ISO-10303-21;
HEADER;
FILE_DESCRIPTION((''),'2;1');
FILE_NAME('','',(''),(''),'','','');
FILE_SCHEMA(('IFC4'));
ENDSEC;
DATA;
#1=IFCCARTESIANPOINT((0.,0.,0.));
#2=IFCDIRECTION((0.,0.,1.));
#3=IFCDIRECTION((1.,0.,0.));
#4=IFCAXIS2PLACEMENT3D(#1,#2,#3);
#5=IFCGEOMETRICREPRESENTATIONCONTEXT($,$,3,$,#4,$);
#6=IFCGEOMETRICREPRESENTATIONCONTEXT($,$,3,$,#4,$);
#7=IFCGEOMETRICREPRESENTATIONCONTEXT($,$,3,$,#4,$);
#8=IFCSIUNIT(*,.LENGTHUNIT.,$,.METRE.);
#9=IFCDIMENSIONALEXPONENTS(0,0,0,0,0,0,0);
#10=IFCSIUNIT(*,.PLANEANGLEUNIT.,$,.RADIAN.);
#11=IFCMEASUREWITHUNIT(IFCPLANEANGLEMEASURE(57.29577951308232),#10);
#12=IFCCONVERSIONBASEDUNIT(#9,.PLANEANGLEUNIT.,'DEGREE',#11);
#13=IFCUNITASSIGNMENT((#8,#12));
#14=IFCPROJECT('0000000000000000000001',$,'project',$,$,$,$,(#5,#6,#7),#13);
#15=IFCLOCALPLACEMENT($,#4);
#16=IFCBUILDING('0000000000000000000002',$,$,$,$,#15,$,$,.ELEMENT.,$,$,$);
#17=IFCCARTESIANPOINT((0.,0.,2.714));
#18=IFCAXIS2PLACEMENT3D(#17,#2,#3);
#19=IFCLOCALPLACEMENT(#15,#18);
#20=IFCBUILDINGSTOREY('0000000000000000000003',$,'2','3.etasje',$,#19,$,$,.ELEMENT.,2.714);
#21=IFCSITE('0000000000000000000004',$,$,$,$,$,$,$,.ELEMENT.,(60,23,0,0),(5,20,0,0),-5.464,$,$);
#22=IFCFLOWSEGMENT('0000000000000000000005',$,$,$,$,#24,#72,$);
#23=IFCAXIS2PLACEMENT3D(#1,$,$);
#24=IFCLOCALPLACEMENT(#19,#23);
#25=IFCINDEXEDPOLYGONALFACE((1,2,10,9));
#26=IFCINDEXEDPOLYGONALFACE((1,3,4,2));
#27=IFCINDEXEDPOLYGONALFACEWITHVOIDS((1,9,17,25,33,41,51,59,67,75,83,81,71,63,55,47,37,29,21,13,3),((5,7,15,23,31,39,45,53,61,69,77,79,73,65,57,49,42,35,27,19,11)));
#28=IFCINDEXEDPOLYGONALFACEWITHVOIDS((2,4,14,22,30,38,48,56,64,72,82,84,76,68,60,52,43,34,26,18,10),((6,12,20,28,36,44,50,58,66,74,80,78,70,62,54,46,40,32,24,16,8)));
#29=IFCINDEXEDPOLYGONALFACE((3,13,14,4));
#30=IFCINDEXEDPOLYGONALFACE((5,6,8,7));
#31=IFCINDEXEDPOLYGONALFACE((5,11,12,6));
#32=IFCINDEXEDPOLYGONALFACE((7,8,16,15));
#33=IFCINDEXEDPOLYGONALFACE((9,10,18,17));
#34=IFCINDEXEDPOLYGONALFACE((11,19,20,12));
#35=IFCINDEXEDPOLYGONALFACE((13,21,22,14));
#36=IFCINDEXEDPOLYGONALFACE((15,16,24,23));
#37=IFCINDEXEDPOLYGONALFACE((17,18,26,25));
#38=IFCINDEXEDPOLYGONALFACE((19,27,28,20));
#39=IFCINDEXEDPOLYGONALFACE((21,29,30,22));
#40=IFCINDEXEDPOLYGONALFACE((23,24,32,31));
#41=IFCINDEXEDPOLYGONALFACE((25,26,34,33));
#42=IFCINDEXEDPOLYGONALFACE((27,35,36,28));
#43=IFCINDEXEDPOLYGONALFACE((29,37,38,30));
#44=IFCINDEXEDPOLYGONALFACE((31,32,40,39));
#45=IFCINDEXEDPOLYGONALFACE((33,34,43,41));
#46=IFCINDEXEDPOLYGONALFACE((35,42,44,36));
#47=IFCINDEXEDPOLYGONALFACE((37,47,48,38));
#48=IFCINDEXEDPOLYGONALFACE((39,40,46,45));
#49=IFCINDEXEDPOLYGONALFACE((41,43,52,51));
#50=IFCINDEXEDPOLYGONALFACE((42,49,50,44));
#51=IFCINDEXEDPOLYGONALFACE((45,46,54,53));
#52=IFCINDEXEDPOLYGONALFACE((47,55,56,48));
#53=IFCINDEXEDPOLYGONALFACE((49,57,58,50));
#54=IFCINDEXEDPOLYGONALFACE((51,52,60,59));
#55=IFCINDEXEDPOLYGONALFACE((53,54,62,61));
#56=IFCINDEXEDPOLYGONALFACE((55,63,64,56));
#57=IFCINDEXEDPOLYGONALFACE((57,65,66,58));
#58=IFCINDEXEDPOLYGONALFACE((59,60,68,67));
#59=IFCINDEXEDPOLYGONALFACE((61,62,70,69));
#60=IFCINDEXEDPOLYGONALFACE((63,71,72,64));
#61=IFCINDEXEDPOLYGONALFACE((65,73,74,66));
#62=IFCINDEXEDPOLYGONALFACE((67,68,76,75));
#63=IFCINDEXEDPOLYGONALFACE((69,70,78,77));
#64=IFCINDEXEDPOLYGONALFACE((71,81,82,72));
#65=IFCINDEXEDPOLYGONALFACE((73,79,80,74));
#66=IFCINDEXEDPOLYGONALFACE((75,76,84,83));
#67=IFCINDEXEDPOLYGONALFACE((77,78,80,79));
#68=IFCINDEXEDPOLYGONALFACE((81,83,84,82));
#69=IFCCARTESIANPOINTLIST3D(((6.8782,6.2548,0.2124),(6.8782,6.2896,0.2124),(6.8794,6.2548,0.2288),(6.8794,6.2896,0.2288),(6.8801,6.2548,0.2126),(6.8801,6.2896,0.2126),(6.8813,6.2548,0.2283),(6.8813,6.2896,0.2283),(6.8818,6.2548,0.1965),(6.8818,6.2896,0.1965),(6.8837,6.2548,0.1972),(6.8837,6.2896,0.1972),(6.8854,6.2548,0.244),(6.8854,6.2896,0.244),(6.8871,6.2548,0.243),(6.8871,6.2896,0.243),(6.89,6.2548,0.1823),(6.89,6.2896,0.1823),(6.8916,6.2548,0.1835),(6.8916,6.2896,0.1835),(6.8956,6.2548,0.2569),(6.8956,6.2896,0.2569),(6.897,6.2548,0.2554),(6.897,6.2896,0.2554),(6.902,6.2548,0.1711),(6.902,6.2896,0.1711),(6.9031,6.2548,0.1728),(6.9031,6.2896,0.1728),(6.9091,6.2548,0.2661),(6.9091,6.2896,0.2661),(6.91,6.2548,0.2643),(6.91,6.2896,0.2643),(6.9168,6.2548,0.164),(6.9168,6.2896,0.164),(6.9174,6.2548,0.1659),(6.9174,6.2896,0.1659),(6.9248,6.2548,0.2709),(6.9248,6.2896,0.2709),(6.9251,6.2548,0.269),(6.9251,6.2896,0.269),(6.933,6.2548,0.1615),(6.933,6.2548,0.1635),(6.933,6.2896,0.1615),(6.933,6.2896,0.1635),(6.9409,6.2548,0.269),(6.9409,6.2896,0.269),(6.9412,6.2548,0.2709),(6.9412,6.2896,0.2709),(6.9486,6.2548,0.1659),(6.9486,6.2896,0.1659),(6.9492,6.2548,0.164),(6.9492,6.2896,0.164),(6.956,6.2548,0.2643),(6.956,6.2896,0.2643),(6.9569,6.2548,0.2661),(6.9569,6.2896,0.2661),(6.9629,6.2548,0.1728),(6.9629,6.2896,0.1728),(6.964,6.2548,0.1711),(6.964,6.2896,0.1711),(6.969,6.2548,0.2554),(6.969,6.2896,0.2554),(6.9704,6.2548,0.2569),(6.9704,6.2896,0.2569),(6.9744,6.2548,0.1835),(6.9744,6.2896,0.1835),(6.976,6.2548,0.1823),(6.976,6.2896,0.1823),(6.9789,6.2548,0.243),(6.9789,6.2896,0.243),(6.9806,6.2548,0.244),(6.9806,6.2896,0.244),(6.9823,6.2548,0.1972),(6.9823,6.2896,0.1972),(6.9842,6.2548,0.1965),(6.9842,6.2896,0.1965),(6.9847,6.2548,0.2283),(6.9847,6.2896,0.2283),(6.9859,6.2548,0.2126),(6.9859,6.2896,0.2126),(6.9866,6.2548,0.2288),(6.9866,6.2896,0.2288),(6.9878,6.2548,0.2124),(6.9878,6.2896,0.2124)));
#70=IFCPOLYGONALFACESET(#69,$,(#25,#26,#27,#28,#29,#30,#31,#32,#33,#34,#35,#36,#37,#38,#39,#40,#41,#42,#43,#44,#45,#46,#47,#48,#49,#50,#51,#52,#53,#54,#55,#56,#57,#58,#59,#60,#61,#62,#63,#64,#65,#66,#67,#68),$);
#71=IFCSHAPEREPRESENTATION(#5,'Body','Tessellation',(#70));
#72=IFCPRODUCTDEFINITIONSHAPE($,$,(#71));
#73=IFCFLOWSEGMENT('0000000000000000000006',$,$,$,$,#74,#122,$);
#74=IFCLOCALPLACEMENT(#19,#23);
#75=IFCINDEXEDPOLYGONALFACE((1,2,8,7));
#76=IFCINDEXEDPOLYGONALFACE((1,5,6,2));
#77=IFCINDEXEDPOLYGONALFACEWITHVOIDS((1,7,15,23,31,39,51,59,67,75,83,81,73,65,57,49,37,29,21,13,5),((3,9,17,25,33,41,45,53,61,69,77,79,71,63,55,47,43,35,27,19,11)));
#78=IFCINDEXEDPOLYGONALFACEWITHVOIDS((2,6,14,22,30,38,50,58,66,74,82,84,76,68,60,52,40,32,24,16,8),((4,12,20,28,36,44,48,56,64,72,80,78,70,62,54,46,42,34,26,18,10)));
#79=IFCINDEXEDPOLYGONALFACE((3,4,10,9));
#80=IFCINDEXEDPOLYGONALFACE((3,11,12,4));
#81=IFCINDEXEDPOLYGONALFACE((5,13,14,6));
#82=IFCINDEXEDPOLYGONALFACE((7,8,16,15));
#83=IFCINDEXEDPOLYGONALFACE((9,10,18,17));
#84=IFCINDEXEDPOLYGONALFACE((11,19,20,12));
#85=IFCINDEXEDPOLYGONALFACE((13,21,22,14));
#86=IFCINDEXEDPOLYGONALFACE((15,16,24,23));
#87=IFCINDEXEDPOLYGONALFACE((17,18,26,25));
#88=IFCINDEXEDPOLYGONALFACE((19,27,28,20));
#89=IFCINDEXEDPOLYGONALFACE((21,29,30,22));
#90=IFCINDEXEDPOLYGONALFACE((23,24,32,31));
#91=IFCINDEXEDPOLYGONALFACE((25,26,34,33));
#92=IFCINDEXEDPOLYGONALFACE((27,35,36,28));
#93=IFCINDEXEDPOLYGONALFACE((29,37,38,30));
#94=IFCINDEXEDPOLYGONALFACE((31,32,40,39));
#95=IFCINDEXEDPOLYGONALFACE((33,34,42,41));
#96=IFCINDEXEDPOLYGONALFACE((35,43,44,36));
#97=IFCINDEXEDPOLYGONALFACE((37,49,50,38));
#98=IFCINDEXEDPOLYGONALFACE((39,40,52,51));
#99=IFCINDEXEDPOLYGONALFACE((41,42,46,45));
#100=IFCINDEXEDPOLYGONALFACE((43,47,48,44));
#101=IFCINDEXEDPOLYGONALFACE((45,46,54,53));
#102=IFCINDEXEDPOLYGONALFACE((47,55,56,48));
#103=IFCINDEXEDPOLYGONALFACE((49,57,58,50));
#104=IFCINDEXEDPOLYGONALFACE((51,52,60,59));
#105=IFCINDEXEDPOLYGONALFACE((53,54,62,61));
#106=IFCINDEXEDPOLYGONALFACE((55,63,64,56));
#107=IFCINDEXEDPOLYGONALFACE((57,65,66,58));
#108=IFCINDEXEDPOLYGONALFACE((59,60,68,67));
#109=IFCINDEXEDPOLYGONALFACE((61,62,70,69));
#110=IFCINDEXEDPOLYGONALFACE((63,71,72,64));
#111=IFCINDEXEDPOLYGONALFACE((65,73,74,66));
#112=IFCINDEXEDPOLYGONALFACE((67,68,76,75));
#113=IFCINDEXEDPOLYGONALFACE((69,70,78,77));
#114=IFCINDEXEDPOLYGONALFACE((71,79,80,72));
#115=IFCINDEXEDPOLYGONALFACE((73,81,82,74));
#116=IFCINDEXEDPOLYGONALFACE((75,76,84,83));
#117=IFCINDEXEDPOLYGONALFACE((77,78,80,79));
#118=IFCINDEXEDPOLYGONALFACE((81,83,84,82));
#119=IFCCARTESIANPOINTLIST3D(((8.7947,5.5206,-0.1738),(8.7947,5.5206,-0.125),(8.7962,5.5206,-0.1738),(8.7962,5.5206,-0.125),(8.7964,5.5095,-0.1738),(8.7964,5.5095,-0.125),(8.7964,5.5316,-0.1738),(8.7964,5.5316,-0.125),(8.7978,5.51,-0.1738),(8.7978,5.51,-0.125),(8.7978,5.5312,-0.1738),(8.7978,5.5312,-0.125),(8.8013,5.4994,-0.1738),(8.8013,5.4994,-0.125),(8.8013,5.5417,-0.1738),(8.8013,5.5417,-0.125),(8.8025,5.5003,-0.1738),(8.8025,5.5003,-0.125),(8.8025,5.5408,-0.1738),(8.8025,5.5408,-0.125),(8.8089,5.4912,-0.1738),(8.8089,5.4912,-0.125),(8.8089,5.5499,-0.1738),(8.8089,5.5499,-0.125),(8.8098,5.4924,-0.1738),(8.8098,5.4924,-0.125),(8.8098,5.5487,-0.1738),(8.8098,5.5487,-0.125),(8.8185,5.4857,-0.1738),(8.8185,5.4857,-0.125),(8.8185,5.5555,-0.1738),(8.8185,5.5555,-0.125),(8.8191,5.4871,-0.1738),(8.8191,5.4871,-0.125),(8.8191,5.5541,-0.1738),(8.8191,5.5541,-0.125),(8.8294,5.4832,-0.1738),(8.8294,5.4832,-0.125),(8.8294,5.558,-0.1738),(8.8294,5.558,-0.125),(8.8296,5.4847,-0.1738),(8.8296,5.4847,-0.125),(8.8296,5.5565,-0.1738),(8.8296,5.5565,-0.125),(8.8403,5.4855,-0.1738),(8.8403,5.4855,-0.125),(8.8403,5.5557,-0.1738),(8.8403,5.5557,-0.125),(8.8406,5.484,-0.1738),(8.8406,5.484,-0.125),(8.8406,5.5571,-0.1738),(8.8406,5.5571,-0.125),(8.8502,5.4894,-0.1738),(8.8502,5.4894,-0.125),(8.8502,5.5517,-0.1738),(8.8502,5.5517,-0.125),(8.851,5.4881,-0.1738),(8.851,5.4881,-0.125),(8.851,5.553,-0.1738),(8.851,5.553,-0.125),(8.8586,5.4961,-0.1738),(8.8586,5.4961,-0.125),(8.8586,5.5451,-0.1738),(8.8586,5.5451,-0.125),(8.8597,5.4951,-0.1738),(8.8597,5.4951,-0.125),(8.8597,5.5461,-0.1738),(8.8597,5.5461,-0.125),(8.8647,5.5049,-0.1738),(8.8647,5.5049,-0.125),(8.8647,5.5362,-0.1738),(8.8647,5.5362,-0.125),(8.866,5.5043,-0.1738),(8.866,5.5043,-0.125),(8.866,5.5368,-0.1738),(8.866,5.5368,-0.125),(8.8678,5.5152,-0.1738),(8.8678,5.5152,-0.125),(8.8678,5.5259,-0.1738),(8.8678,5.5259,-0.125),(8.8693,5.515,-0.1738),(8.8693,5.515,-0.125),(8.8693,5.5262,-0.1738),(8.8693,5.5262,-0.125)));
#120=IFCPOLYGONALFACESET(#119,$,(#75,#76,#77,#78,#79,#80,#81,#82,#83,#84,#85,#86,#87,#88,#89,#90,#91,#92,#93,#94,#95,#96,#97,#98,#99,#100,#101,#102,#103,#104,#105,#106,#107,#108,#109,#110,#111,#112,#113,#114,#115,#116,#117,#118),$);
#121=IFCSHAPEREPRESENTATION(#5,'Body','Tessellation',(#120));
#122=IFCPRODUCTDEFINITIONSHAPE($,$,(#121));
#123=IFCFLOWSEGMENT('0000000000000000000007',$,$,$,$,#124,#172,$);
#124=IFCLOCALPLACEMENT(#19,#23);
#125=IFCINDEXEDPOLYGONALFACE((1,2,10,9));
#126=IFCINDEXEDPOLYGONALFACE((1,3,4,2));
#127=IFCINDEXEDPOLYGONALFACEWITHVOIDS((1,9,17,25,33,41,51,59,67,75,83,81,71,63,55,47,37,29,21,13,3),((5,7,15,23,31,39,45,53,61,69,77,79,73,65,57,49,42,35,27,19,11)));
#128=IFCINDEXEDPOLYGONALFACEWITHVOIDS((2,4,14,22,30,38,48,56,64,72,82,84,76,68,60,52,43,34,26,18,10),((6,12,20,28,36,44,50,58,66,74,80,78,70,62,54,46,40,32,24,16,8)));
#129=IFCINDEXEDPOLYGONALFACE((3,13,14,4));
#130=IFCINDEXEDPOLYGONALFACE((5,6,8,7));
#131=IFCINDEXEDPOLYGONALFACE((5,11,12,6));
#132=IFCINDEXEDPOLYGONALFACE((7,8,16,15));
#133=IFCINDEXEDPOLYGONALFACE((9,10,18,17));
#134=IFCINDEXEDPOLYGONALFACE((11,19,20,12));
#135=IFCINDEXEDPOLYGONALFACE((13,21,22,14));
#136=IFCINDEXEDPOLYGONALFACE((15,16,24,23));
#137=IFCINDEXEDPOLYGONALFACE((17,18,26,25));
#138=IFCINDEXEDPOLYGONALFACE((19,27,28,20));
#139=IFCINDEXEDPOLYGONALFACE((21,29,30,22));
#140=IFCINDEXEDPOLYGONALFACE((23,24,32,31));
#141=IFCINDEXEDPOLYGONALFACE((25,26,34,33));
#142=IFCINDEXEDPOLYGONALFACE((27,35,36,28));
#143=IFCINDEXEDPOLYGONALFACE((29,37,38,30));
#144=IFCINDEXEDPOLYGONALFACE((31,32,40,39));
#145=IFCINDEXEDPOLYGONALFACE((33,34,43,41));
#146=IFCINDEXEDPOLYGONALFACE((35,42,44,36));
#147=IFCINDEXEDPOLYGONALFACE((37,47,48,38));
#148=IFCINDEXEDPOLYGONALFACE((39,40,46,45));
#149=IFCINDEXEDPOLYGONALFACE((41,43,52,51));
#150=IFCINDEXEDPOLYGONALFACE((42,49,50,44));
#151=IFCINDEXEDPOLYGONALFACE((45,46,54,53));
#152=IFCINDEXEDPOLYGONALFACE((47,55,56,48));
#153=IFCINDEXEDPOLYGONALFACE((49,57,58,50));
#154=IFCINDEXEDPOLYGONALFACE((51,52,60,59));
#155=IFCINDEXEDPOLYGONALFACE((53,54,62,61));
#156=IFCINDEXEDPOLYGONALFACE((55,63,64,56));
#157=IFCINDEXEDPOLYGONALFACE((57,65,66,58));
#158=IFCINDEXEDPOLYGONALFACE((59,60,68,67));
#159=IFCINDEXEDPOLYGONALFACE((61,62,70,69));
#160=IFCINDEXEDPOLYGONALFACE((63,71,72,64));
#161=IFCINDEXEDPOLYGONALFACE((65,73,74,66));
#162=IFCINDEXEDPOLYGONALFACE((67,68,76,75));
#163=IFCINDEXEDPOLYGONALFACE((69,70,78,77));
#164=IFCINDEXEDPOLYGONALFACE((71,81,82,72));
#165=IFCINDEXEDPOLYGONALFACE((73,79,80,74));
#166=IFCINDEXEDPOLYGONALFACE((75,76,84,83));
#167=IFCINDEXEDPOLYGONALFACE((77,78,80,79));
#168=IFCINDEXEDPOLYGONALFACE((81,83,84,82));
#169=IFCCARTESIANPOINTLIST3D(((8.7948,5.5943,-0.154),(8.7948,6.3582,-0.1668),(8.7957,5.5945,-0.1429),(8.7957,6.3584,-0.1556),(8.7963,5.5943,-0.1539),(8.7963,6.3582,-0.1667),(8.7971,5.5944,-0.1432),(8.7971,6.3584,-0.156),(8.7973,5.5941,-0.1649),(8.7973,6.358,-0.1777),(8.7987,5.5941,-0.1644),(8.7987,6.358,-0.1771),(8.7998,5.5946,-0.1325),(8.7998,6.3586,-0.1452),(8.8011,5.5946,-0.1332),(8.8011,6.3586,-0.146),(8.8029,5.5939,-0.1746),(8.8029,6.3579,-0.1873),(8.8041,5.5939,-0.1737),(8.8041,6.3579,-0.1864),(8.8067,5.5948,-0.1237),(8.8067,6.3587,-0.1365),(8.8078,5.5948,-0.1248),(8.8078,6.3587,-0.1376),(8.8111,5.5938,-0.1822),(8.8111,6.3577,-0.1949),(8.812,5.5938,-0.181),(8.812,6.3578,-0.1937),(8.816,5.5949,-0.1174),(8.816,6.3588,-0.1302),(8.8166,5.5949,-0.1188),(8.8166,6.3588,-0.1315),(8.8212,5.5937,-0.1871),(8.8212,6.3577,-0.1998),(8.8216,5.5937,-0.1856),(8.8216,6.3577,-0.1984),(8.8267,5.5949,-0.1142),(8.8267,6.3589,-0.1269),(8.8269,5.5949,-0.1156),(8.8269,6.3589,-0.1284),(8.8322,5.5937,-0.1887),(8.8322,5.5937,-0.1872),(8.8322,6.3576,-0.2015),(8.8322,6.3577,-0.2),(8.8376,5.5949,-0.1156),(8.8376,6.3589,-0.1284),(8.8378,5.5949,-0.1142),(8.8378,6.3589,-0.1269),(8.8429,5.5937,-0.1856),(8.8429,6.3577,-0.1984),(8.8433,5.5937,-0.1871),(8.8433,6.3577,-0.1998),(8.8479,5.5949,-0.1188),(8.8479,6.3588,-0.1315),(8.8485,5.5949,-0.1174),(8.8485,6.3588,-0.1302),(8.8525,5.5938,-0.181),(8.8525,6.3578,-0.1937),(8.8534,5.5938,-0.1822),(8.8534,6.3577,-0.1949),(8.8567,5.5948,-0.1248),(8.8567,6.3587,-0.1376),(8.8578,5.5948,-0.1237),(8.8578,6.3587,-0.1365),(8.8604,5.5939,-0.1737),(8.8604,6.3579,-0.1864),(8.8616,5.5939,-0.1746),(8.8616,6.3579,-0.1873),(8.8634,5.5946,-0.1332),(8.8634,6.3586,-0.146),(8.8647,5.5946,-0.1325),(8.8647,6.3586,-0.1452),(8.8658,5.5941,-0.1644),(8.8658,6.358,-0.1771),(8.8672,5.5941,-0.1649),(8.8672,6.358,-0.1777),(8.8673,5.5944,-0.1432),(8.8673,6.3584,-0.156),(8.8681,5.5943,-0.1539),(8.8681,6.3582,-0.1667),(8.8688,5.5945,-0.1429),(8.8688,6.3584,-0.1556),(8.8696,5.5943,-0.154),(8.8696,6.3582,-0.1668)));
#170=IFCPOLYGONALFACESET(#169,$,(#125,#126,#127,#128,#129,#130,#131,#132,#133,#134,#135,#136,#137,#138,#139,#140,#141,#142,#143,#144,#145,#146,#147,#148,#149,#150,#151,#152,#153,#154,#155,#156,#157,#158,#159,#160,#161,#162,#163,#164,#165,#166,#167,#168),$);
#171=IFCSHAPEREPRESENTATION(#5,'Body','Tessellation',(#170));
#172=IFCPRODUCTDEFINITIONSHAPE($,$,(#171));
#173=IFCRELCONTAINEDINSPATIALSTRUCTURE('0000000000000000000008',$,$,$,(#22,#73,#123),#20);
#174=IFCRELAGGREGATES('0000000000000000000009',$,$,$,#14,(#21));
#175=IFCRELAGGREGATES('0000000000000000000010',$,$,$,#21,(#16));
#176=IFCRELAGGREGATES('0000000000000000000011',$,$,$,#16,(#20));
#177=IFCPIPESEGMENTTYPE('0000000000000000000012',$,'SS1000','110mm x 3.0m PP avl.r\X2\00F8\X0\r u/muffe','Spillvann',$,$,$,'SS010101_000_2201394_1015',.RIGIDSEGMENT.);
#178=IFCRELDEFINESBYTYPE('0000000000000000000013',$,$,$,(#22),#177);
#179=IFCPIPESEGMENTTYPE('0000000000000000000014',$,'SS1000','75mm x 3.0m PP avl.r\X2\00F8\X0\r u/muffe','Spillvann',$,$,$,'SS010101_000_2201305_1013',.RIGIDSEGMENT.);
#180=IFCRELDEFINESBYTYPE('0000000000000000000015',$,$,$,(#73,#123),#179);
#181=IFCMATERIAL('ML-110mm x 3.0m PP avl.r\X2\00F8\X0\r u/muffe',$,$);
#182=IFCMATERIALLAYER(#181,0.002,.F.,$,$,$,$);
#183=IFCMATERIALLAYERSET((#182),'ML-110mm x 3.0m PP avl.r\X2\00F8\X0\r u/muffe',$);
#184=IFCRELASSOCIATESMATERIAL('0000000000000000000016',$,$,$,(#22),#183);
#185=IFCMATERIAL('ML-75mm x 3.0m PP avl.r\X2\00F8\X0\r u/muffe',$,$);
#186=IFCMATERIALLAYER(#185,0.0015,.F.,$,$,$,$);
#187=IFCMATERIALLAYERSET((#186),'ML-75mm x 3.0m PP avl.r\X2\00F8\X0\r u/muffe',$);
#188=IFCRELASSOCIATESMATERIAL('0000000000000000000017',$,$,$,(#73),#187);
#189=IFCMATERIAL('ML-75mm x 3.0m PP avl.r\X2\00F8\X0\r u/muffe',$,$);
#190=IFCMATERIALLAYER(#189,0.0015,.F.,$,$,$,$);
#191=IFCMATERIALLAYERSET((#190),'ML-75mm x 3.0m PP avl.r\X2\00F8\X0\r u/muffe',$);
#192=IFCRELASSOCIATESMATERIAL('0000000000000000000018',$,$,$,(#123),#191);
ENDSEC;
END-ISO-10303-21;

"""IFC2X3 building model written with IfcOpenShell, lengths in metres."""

from ifc_helpers import new_model, entity, si_unit, converted_unit, frame, origin_with_axes, origin_2d_with_axis, place, context, project, spatial, hollow_circle, extrude, material, layer, layer_set, layer_usage, type_object, element, save


model = new_model("IFC2X3")

# Units and contexts
context_of_model_1 = context(None, 3, world=origin_with_axes())
context_of_model_2 = context(None, 3, world=origin_with_axes())
context_of_model_3 = context(None, 3, world=origin_with_axes())
ifc_project = project(units=[si_unit("LENGTHUNIT", "METRE"), converted_unit("PLANEANGLEUNIT", "DEGREE", entity("IfcPlaneAngleMeasure", 57.29577951308232), si_unit("PLANEANGLEUNIT", "RADIAN"), dimensions=[0, 0, 0, 0, 0, 0, 0])], contexts=[context_of_model_1, context_of_model_2, context_of_model_3])

# Site, building, storey
site = spatial("IfcSite", under=ifc_project, CompositionType="ELEMENT", RefLatitude=(60, 23, 0, 0), RefLongitude=(5, 20, 0, 0), RefElevation=-5.464)
building_placement = place(None, origin_with_axes())
building = spatial("IfcBuilding", under=site, at=building_placement, CompositionType="ELEMENT")
storey_placement = place(building_placement, frame((0.0, 0.0, 2.714), z_axis=(0.0, 0.0, 1.0), x_axis=(1.0, 0.0, 0.0)))
storey = spatial("IfcBuildingStorey", under=building, at=storey_placement, Name="2", Description="3.etasje", CompositionType="ELEMENT", Elevation=2.714)

# Flow segments
pipe_segment_type_1 = type_object("IfcPipeSegmentType", Name="SS1000", Description="110mm x 3.0m PP avl.rør u/muffe", ApplicableOccurrence="Spillvann", ElementType="SS010101_000_2201394_1015", PredefinedType="RIGIDSEGMENT")
ifc_material_1 = material(Name="ML-110mm x 3.0m PP avl.rør u/muffe")
ifc_layer_1 = layer(ifc_material_1, 0.002, ventilated=False)
ifc_layer_set_1 = layer_set([ifc_layer_1], Name="ML-110mm x 3.0m PP avl.rør u/muffe")
ifc_layer_usage_1 = layer_usage(ifc_layer_set_1, "AXIS2", "POSITIVE", 0.0)
flow_segment_1_placement = place(storey_placement, frame((6.933, 6.2896, 0.2165), z_axis=(0.0, -1.0, 0.0), x_axis=(0.0, 0.0, -1.0)))
element("IfcFlowSegment", 1, at=flow_segment_1_placement, inside=storey, type_object=pipe_segment_type_1, material=ifc_layer_usage_1, context=context_of_model_1, shape_type="SweptSolid", body=[
    extrude(hollow_circle(Radius=0.055, WallThickness=0.002, at=origin_2d_with_axis()), origin_with_axes(), (0.0, 0.0, 1.0), 0.0348),
])
ifc_material_2 = material(Name="ML-75mm x 3.0m PP avl.rør u/muffe")
ifc_layer_2 = layer(ifc_material_2, 0.0015, ventilated=False)
ifc_layer_set_2 = layer_set([ifc_layer_2], Name="ML-75mm x 3.0m PP avl.rør u/muffe")
ifc_layer_usage_2 = layer_usage(ifc_layer_set_2, "AXIS2", "POSITIVE", 0.0)
pipe_segment_type_2 = type_object("IfcPipeSegmentType", Name="SS1000", Description="75mm x 3.0m PP avl.rør u/muffe", ApplicableOccurrence="Spillvann", ElementType="SS010101_000_2201305_1013", PredefinedType="RIGIDSEGMENT")
flow_segment_2_placement = place(storey_placement, frame((8.8322, 5.5206, -0.125), z_axis=(0.0, 0.0, -1.0), x_axis=(-1.0, 0.0, 0.0)))
element("IfcFlowSegment", 2, at=flow_segment_2_placement, inside=storey, type_object=pipe_segment_type_2, material=ifc_layer_usage_2, context=context_of_model_1, shape_type="SweptSolid", body=[
    extrude(hollow_circle(Radius=0.0375, WallThickness=0.0015, at=origin_2d_with_axis()), origin_with_axes(), (0.0, 0.0, 1.0), 0.0488),
])
ifc_material_3 = material(Name="ML-75mm x 3.0m PP avl.rør u/muffe")
ifc_layer_3 = layer(ifc_material_3, 0.0015, ventilated=False)
ifc_layer_set_3 = layer_set([ifc_layer_3], Name="ML-75mm x 3.0m PP avl.rør u/muffe")
ifc_layer_usage_3 = layer_usage(ifc_layer_set_3, "AXIS2", "POSITIVE", 0.0)
flow_segment_3_placement = place(storey_placement, frame((8.8322, 5.5943, -0.1512), z_axis=(0.0, 0.999861, -0.016665), x_axis=(0.0, -0.016665, -0.999861)))
element("IfcFlowSegment", 3, at=flow_segment_3_placement, inside=storey, type_object=pipe_segment_type_2, material=ifc_layer_usage_3, context=context_of_model_1, shape_type="SweptSolid", body=[
    extrude(hollow_circle(Radius=0.0375, WallThickness=0.0015, at=origin_2d_with_axis()), origin_with_axes(), (0.0, 0.0, 1.0), 0.764),
])

save(model, "model.ifc")
